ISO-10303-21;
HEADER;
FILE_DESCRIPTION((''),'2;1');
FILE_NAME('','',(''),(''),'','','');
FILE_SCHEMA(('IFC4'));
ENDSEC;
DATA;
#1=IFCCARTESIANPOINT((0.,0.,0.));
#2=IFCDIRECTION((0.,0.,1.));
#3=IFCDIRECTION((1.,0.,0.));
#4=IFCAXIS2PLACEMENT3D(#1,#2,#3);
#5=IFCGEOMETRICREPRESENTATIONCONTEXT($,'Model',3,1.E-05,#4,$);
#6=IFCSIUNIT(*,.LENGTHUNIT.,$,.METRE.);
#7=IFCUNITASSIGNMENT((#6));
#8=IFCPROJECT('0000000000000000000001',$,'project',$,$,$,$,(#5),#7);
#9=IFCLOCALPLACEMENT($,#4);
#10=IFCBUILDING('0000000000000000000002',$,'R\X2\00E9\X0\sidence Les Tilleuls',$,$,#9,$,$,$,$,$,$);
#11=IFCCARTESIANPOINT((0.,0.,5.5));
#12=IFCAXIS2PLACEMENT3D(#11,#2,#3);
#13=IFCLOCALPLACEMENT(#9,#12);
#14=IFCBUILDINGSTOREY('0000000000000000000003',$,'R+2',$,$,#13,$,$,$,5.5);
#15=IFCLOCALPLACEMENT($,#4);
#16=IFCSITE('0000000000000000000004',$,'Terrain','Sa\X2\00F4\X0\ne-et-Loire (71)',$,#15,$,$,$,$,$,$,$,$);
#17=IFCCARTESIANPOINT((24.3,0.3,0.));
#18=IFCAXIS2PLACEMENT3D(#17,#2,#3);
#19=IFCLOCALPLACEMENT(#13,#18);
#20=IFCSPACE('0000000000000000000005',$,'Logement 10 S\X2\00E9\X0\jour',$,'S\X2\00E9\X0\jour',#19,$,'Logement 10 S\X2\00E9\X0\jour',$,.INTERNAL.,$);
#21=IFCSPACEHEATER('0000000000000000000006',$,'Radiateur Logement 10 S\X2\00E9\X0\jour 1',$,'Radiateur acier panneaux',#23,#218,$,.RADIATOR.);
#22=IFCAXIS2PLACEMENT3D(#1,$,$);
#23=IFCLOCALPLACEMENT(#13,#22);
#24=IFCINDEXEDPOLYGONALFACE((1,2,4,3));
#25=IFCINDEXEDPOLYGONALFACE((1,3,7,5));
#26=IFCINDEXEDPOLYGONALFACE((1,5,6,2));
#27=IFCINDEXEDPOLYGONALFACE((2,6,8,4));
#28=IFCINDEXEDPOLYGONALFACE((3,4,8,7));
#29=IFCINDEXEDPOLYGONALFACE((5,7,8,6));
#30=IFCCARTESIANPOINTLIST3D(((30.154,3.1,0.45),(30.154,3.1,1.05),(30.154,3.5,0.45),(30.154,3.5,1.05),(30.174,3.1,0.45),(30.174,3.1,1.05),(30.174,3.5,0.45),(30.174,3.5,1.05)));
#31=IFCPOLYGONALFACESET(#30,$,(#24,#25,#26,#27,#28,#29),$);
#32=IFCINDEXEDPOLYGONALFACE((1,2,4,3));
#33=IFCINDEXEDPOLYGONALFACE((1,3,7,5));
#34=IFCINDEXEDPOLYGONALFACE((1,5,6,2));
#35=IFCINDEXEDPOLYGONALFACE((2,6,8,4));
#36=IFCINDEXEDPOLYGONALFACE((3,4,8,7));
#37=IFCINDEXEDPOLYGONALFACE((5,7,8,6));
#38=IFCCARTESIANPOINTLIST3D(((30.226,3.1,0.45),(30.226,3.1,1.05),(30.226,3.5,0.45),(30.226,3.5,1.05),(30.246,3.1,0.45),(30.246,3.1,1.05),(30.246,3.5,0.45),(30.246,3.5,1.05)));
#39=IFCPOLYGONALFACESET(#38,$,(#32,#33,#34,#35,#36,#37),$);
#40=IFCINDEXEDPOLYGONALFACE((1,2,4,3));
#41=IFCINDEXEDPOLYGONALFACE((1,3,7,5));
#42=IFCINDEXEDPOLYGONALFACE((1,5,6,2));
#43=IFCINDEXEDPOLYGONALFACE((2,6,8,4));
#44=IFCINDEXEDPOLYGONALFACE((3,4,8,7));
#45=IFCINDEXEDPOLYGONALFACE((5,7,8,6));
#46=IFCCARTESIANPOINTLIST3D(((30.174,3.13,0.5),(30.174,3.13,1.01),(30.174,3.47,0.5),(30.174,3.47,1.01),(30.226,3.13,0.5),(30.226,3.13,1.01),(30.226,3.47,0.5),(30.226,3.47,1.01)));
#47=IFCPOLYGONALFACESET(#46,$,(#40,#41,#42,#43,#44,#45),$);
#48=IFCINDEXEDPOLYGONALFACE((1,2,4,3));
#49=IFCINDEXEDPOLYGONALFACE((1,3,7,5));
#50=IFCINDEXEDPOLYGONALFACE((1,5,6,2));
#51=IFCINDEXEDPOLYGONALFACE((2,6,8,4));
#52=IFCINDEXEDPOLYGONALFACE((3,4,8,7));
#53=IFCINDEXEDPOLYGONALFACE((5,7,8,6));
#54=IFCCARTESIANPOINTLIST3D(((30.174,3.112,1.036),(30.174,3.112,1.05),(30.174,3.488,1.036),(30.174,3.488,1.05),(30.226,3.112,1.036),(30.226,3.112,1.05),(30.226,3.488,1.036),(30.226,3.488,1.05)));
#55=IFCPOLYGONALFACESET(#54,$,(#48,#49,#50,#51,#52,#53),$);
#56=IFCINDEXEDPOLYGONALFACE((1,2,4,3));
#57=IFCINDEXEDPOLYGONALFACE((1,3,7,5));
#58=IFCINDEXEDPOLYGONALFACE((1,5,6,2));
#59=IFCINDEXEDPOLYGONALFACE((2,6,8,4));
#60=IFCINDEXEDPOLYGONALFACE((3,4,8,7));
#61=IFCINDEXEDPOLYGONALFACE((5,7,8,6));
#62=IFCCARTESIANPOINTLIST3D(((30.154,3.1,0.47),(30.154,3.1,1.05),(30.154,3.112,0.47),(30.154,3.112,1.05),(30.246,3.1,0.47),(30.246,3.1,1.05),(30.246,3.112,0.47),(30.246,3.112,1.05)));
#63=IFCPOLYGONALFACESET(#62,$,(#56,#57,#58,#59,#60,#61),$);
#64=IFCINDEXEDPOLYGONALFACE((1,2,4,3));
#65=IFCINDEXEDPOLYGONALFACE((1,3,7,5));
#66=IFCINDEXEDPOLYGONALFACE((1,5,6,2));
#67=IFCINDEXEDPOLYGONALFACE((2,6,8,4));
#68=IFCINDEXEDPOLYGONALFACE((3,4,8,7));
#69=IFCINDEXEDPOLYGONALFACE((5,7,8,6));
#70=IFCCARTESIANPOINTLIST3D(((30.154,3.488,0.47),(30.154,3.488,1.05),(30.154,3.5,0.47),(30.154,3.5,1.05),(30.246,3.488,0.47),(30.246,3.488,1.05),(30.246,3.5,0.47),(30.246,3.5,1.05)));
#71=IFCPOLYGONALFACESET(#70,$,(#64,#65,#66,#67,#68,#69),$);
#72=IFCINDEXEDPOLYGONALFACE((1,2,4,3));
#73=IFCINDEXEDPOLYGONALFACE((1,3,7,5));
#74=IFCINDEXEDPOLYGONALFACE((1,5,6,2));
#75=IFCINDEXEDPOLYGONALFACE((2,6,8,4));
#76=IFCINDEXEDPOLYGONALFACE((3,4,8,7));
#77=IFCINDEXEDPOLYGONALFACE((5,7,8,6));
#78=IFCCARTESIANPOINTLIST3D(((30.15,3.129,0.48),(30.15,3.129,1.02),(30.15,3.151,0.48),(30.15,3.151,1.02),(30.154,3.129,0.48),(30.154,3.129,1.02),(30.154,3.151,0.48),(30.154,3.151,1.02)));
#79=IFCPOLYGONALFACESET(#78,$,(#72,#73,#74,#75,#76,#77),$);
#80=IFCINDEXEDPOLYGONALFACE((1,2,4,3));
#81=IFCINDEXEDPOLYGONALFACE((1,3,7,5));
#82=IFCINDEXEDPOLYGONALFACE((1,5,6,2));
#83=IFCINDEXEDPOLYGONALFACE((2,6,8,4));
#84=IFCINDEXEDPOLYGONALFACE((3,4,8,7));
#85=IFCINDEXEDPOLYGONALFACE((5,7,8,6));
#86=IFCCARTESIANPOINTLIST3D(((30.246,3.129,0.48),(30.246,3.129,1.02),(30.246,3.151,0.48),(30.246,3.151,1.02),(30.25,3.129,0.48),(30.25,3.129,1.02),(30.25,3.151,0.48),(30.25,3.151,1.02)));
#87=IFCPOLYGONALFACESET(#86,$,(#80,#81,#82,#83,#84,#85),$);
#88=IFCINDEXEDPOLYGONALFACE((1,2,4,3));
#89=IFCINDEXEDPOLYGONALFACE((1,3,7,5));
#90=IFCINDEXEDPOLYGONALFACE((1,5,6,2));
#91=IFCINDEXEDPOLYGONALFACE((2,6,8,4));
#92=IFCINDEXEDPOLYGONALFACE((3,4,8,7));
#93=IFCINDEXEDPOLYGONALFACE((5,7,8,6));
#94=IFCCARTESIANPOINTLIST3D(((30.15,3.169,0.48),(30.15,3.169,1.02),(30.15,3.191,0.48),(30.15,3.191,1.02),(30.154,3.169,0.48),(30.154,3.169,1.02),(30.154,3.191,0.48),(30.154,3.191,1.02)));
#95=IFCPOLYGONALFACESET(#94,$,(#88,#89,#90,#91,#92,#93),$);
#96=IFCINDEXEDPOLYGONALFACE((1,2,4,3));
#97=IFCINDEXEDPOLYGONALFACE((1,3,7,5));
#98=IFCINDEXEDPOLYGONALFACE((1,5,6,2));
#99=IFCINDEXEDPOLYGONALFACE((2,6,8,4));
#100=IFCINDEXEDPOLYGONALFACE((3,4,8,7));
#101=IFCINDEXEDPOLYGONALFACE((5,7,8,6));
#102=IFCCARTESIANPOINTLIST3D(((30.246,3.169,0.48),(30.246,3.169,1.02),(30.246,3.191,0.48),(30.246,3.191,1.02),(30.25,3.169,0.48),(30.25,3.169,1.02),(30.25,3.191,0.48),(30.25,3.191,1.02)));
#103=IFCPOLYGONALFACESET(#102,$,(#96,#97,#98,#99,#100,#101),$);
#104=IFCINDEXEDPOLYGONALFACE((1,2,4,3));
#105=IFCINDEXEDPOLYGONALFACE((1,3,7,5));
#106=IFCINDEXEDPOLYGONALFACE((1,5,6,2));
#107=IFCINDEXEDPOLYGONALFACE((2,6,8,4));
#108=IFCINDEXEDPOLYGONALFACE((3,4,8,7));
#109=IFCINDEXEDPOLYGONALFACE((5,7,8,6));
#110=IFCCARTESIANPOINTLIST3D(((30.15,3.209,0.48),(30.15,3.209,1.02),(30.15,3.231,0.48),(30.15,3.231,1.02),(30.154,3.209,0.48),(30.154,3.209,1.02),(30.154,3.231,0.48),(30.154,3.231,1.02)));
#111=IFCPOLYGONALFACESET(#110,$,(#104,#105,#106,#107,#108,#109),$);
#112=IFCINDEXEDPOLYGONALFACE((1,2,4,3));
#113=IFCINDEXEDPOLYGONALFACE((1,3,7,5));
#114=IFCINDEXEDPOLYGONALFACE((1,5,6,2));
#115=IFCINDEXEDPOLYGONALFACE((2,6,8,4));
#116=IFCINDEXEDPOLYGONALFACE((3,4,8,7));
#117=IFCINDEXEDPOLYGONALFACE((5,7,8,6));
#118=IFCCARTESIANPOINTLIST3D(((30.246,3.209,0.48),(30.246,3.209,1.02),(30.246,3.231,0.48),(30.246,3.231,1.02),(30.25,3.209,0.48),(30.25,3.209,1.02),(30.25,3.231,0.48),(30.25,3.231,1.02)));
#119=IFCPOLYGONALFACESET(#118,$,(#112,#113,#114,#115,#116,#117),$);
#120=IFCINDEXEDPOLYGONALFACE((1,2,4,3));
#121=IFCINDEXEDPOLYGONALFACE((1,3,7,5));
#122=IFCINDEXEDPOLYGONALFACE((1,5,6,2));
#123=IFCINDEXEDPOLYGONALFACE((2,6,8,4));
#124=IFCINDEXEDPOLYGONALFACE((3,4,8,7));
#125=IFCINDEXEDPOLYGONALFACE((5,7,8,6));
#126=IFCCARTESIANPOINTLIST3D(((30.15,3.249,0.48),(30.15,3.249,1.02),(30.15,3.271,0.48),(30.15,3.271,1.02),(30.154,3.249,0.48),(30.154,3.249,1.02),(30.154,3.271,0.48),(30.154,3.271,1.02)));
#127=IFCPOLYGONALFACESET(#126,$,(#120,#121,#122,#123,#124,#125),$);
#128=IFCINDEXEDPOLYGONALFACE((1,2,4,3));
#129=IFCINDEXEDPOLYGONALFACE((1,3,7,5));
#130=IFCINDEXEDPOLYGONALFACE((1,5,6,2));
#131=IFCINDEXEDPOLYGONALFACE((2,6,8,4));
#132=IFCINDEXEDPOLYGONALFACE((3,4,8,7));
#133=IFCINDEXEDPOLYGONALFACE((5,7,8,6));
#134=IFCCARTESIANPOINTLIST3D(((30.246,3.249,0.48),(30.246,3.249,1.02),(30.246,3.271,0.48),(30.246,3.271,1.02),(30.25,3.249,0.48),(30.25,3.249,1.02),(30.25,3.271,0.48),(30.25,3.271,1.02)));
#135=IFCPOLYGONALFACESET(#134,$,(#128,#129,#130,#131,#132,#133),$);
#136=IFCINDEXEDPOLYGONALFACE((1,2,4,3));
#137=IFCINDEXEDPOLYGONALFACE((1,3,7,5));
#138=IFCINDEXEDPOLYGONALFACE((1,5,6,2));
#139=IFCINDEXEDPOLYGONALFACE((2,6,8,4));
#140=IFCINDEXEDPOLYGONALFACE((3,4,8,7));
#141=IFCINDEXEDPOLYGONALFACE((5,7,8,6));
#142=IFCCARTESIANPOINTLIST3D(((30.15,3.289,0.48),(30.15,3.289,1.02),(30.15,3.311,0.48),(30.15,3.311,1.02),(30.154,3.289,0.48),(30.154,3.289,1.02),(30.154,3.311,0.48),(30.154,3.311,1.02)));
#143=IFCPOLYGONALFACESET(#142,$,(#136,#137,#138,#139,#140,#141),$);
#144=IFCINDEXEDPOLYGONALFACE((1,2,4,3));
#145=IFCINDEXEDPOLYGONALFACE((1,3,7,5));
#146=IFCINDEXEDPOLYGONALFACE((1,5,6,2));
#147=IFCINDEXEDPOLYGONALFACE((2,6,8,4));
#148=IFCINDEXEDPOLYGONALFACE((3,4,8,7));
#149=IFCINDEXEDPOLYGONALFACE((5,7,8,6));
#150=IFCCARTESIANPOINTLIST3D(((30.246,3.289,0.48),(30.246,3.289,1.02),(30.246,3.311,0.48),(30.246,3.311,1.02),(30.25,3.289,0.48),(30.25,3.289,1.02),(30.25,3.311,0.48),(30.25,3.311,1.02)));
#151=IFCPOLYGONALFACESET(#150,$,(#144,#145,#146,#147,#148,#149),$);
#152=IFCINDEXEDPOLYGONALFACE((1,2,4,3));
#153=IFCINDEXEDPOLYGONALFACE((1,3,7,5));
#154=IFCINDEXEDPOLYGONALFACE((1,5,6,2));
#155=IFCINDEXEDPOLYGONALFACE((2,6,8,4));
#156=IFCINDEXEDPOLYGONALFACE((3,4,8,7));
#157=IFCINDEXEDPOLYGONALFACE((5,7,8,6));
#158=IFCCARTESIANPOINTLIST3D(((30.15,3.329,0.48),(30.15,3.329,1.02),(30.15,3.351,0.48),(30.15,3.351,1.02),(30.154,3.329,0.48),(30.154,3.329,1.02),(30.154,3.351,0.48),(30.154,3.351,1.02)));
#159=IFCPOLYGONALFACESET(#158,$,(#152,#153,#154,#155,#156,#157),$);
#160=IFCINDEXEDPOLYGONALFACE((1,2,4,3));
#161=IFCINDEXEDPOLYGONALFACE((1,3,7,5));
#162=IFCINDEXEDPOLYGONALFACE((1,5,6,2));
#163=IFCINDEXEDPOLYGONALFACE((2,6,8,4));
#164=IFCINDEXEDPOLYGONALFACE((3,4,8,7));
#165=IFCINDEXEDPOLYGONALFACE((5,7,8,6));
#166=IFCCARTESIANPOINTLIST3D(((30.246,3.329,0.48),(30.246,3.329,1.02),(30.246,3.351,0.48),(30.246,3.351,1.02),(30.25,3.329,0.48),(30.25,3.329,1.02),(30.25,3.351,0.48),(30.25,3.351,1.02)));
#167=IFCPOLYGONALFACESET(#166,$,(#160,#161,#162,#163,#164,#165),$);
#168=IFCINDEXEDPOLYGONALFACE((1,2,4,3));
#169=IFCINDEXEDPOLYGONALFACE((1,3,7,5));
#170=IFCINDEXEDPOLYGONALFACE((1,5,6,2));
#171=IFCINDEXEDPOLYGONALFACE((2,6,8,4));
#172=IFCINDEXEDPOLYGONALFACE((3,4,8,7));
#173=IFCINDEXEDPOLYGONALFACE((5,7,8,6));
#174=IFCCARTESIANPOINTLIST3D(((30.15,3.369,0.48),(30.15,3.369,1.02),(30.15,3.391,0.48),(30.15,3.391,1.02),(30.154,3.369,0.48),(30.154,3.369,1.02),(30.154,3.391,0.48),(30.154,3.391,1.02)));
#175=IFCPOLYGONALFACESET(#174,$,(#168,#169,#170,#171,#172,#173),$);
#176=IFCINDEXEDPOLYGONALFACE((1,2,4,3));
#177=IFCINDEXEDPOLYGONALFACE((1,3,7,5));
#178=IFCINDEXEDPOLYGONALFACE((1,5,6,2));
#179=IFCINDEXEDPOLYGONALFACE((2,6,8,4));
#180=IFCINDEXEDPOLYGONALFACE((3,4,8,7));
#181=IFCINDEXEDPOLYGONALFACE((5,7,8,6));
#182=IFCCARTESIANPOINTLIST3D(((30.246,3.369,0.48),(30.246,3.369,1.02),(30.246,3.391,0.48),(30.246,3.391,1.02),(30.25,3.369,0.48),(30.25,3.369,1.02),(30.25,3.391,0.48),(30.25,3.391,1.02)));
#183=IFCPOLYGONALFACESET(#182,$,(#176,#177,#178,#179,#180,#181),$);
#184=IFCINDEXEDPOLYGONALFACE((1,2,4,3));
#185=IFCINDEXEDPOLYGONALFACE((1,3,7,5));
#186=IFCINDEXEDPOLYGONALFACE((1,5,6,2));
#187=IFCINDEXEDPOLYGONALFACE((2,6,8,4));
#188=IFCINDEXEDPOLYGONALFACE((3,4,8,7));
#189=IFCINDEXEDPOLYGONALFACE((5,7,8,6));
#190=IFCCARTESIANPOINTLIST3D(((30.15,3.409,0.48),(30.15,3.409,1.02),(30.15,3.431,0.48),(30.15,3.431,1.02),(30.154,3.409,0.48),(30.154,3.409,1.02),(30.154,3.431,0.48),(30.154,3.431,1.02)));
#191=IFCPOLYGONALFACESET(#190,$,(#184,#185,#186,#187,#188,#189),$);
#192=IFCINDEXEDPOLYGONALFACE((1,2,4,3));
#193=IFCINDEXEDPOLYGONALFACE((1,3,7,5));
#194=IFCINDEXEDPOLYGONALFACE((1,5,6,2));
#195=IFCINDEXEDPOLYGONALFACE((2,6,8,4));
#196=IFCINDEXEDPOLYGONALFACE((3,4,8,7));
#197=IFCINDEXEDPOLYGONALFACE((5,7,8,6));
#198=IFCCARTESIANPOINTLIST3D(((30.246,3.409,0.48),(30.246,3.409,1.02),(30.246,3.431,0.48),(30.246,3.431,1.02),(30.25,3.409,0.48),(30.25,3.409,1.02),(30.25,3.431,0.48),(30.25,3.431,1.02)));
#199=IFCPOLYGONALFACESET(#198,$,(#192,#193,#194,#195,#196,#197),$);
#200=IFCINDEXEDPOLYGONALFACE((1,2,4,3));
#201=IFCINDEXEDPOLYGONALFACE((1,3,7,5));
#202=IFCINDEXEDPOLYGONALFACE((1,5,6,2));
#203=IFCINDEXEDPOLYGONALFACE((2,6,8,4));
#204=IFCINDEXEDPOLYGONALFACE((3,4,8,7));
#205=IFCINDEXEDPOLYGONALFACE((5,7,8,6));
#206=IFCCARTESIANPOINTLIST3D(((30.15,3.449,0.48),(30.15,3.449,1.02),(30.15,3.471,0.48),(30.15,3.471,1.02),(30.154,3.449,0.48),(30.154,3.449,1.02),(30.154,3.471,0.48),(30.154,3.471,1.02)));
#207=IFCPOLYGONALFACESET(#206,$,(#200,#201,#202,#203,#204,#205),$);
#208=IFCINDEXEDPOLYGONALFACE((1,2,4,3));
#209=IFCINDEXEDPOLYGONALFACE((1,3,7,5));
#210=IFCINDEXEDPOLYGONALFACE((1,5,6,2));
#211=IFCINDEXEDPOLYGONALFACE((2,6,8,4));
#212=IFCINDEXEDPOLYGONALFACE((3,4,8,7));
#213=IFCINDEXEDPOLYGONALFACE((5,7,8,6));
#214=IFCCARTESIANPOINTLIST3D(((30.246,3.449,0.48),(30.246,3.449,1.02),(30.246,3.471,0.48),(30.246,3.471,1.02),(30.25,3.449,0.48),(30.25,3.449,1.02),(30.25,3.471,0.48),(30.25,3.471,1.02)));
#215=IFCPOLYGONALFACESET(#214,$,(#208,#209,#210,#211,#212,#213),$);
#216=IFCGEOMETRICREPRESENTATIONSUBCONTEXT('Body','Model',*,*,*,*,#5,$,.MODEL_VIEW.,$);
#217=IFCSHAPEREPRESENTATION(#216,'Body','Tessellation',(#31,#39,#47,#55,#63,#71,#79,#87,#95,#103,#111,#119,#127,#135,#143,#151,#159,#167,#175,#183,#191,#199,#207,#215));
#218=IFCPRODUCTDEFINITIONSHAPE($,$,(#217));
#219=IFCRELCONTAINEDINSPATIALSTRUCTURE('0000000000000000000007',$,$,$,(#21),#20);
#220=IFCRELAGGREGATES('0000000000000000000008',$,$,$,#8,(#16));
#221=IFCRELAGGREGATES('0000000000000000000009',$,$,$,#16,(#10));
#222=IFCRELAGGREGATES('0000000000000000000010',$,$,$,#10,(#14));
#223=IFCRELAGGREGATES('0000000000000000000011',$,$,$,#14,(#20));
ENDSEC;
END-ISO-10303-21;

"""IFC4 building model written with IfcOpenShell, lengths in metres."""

from ifc_helpers import new_model, si_unit, frame, frame_2d, origin_with_axes, place, context, subcontext, project, spatial, rectangle, extrude, element, save


model = new_model("IFC4")

# Units and contexts
model_context = context("Model", 3, precision=1e-05, world=origin_with_axes())
body_context = subcontext(model_context, "Body", "Model", "MODEL_VIEW")
ifc_project = project(units=[si_unit("LENGTHUNIT", "METRE")], contexts=[model_context])

# Site, building, storey
site_placement = place(None, origin_with_axes())
site = spatial("IfcSite", under=ifc_project, at=site_placement, Name="Terrain", Description="Saône-et-Loire (71)")
building_placement = place(None, origin_with_axes())
building = spatial("IfcBuilding", under=site, at=building_placement, Name="Résidence Les Tilleuls")
storey_placement = place(building_placement, frame((0.0, 0.0, 5.5), z_axis=(0.0, 0.0, 1.0), x_axis=(1.0, 0.0, 0.0)))
storey = spatial("IfcBuildingStorey", under=building, at=storey_placement, Name="R+2", Elevation=5.5)

# Shared definitions
space_placement = place(storey_placement, frame((24.3, 0.3, 0.0), z_axis=(0.0, 0.0, 1.0), x_axis=(1.0, 0.0, 0.0)))
space = spatial("IfcSpace", under=storey, at=space_placement, Name="Logement 10 Séjour", ObjectType="Séjour", LongName="Logement 10 Séjour", PredefinedType="INTERNAL")

# Space heater
space_heater_1_placement = place(space_placement, frame((5.85, 2.8, 0.45), z_axis=(0.0, 0.0, 1.0), x_axis=(1.0, 0.0, 0.0)))
element("IfcSpaceHeater", 1, at=space_heater_1_placement, inside=space, Name="Radiateur Logement 10 Séjour 1", ObjectType="Radiateur acier panneaux", PredefinedType="RADIATOR", context=body_context, shape_type="SweptSolid", body=[
    extrude(rectangle(XDim=0.02, YDim=0.4, at=frame_2d((0.01, 0.2))), frame((0.004, 0.0, 0.0), z_axis=(0.0, 0.0, 1.0), x_axis=(1.0, 0.0, 0.0)), (0.0, 0.0, 1.0), 0.6),
    extrude(rectangle(XDim=0.02, YDim=0.4, at=frame_2d((0.01, 0.2))), frame((0.076, 0.0, 0.0), z_axis=(0.0, 0.0, 1.0), x_axis=(1.0, 0.0, 0.0)), (0.0, 0.0, 1.0), 0.6),
    extrude(rectangle(XDim=0.052, YDim=0.34, at=frame_2d((0.026, 0.17))), frame((0.024, 0.03, 0.05), z_axis=(0.0, 0.0, 1.0), x_axis=(1.0, 0.0, 0.0)), (0.0, 0.0, 1.0), 0.51),
    extrude(rectangle(XDim=0.052, YDim=0.376, at=frame_2d((0.026, 0.188))), frame((0.024, 0.012, 0.586), z_axis=(0.0, 0.0, 1.0), x_axis=(1.0, 0.0, 0.0)), (0.0, 0.0, 1.0), 0.014),
    extrude(rectangle(XDim=0.092, YDim=0.012, at=frame_2d((0.046, 0.006))), frame((0.004, 0.0, 0.02), z_axis=(0.0, 0.0, 1.0), x_axis=(1.0, 0.0, 0.0)), (0.0, 0.0, 1.0), 0.58),
    extrude(rectangle(XDim=0.092, YDim=0.012, at=frame_2d((0.046, 0.006))), frame((0.004, 0.388, 0.02), z_axis=(0.0, 0.0, 1.0), x_axis=(1.0, 0.0, 0.0)), (0.0, 0.0, 1.0), 0.58),
    extrude(rectangle(XDim=0.004, YDim=0.022, at=frame_2d((0.002, 0.011))), frame((0.0, 0.029, 0.03), z_axis=(0.0, 0.0, 1.0), x_axis=(1.0, 0.0, 0.0)), (0.0, 0.0, 1.0), 0.54),
    extrude(rectangle(XDim=0.004, YDim=0.022, at=frame_2d((0.002, 0.011))), frame((0.096, 0.029, 0.03), z_axis=(0.0, 0.0, 1.0), x_axis=(1.0, 0.0, 0.0)), (0.0, 0.0, 1.0), 0.54),
    extrude(rectangle(XDim=0.004, YDim=0.022, at=frame_2d((0.002, 0.011))), frame((0.0, 0.069, 0.03), z_axis=(0.0, 0.0, 1.0), x_axis=(1.0, 0.0, 0.0)), (0.0, 0.0, 1.0), 0.54),
    extrude(rectangle(XDim=0.004, YDim=0.022, at=frame_2d((0.002, 0.011))), frame((0.096, 0.069, 0.03), z_axis=(0.0, 0.0, 1.0), x_axis=(1.0, 0.0, 0.0)), (0.0, 0.0, 1.0), 0.54),
    extrude(rectangle(XDim=0.004, YDim=0.022, at=frame_2d((0.002, 0.011))), frame((0.0, 0.109, 0.03), z_axis=(0.0, 0.0, 1.0), x_axis=(1.0, 0.0, 0.0)), (0.0, 0.0, 1.0), 0.54),
    extrude(rectangle(XDim=0.004, YDim=0.022, at=frame_2d((0.002, 0.011))), frame((0.096, 0.109, 0.03), z_axis=(0.0, 0.0, 1.0), x_axis=(1.0, 0.0, 0.0)), (0.0, 0.0, 1.0), 0.54),
    extrude(rectangle(XDim=0.004, YDim=0.022, at=frame_2d((0.002, 0.011))), frame((0.0, 0.149, 0.03), z_axis=(0.0, 0.0, 1.0), x_axis=(1.0, 0.0, 0.0)), (0.0, 0.0, 1.0), 0.54),
    extrude(rectangle(XDim=0.004, YDim=0.022, at=frame_2d((0.002, 0.011))), frame((0.096, 0.149, 0.03), z_axis=(0.0, 0.0, 1.0), x_axis=(1.0, 0.0, 0.0)), (0.0, 0.0, 1.0), 0.54),
    extrude(rectangle(XDim=0.004, YDim=0.022, at=frame_2d((0.002, 0.011))), frame((0.0, 0.189, 0.03), z_axis=(0.0, 0.0, 1.0), x_axis=(1.0, 0.0, 0.0)), (0.0, 0.0, 1.0), 0.54),
    extrude(rectangle(XDim=0.004, YDim=0.022, at=frame_2d((0.002, 0.011))), frame((0.096, 0.189, 0.03), z_axis=(0.0, 0.0, 1.0), x_axis=(1.0, 0.0, 0.0)), (0.0, 0.0, 1.0), 0.54),
    extrude(rectangle(XDim=0.004, YDim=0.022, at=frame_2d((0.002, 0.011))), frame((0.0, 0.229, 0.03), z_axis=(0.0, 0.0, 1.0), x_axis=(1.0, 0.0, 0.0)), (0.0, 0.0, 1.0), 0.54),
    extrude(rectangle(XDim=0.004, YDim=0.022, at=frame_2d((0.002, 0.011))), frame((0.096, 0.229, 0.03), z_axis=(0.0, 0.0, 1.0), x_axis=(1.0, 0.0, 0.0)), (0.0, 0.0, 1.0), 0.54),
    extrude(rectangle(XDim=0.004, YDim=0.022, at=frame_2d((0.002, 0.011))), frame((0.0, 0.269, 0.03), z_axis=(0.0, 0.0, 1.0), x_axis=(1.0, 0.0, 0.0)), (0.0, 0.0, 1.0), 0.54),
    extrude(rectangle(XDim=0.004, YDim=0.022, at=frame_2d((0.002, 0.011))), frame((0.096, 0.269, 0.03), z_axis=(0.0, 0.0, 1.0), x_axis=(1.0, 0.0, 0.0)), (0.0, 0.0, 1.0), 0.54),
    extrude(rectangle(XDim=0.004, YDim=0.022, at=frame_2d((0.002, 0.011))), frame((0.0, 0.309, 0.03), z_axis=(0.0, 0.0, 1.0), x_axis=(1.0, 0.0, 0.0)), (0.0, 0.0, 1.0), 0.54),
    extrude(rectangle(XDim=0.004, YDim=0.022, at=frame_2d((0.002, 0.011))), frame((0.096, 0.309, 0.03), z_axis=(0.0, 0.0, 1.0), x_axis=(1.0, 0.0, 0.0)), (0.0, 0.0, 1.0), 0.54),
    extrude(rectangle(XDim=0.004, YDim=0.022, at=frame_2d((0.002, 0.011))), frame((0.0, 0.349, 0.03), z_axis=(0.0, 0.0, 1.0), x_axis=(1.0, 0.0, 0.0)), (0.0, 0.0, 1.0), 0.54),
    extrude(rectangle(XDim=0.004, YDim=0.022, at=frame_2d((0.002, 0.011))), frame((0.096, 0.349, 0.03), z_axis=(0.0, 0.0, 1.0), x_axis=(1.0, 0.0, 0.0)), (0.0, 0.0, 1.0), 0.54),
])

save(model, "model.ifc")
